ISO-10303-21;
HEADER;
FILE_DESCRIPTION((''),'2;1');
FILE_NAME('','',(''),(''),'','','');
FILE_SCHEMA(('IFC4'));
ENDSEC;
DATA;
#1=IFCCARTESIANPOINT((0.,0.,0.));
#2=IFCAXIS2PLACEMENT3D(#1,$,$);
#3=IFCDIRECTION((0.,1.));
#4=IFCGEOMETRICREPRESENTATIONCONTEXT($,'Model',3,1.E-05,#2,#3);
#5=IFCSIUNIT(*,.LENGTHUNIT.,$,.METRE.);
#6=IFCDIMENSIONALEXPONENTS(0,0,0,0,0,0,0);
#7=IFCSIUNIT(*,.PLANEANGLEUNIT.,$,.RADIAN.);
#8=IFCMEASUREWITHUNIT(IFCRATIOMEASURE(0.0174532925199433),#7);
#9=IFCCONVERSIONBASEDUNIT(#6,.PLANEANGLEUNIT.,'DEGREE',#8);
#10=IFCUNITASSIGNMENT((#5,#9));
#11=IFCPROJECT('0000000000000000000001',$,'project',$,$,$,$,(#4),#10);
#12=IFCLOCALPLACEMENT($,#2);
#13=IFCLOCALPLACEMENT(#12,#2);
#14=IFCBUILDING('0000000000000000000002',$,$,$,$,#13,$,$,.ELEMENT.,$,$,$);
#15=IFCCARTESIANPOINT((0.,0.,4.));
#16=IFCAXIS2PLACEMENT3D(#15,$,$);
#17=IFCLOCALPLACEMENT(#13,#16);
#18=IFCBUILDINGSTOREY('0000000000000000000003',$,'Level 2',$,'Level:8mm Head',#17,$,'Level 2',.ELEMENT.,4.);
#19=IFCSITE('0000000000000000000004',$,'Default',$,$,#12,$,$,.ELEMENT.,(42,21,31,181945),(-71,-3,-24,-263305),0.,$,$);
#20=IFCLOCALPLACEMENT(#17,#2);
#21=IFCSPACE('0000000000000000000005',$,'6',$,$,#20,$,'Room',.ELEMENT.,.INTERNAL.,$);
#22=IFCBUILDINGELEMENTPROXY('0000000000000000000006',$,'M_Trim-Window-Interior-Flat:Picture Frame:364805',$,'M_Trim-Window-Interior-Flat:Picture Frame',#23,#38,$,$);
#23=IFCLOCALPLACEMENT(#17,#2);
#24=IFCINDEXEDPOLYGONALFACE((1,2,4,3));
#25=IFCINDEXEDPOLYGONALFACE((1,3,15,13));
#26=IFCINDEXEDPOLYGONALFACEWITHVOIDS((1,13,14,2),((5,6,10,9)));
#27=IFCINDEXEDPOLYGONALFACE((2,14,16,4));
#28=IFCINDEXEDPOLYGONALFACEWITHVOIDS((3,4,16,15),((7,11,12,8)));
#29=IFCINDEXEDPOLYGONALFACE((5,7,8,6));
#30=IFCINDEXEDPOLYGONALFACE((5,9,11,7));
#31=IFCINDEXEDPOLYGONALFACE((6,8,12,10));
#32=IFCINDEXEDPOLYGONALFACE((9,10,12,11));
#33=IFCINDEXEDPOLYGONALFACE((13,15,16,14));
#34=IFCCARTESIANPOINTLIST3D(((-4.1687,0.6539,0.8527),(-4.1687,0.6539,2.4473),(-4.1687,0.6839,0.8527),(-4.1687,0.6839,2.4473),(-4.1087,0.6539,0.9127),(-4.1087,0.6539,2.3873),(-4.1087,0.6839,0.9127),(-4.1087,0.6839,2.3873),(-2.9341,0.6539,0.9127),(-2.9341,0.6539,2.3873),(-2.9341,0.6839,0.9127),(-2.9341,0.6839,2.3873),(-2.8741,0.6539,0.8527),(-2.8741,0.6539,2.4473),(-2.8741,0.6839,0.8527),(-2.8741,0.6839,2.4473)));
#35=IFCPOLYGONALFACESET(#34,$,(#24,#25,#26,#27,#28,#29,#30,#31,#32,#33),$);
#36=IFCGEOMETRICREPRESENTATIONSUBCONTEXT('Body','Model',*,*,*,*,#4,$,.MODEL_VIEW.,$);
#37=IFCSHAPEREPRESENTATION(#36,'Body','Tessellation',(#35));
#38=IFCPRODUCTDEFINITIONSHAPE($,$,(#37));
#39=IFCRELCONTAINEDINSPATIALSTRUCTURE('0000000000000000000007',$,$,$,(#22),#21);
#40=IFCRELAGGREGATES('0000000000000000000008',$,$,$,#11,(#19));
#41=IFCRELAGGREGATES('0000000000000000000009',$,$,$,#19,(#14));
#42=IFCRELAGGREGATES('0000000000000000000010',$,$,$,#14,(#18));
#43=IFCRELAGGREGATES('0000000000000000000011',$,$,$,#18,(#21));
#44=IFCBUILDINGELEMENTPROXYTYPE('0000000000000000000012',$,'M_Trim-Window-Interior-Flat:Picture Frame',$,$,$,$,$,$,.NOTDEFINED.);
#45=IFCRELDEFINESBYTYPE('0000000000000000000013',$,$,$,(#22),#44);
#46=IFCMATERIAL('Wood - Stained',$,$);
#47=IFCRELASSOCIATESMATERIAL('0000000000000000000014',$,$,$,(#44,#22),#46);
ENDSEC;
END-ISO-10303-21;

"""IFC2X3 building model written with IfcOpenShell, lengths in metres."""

from ifc_helpers import new_model, entity, si_unit, converted_unit, direction, frame, origin, place, context, subcontext, project, spatial, polyline, outline, extrude, source, transform, mapped, material, type_object, type_shapes, element, save


model = new_model("IFC2X3")

# Units and contexts
model_context = context("Model", 3, precision=1e-05, world=origin(), true_north=direction((0.0, 1.0)))
body_context = subcontext(model_context, "Body", "Model", "MODEL_VIEW")
ifc_project = project(units=[si_unit("LENGTHUNIT", "METRE"), converted_unit("PLANEANGLEUNIT", "DEGREE", entity("IfcRatioMeasure", 0.0174532925199433), si_unit("PLANEANGLEUNIT", "RADIAN"), dimensions=[0, 0, 0, 0, 0, 0, 0])], contexts=[model_context])

# Site, building, storey
site_placement = place(None, origin())
site = spatial("IfcSite", under=ifc_project, at=site_placement, Name="Default", CompositionType="ELEMENT", RefLatitude=(42, 21, 31, 181945), RefLongitude=(-71, -3, -24, -263305), RefElevation=0.0)
building_placement = place(site_placement, origin())
building = spatial("IfcBuilding", under=site, at=building_placement, CompositionType="ELEMENT")
storey_placement = place(building_placement, frame((0.0, 0.0, 4.0)))
storey = spatial("IfcBuildingStorey", under=building, at=storey_placement, Name="Level 2", ObjectType="Level:8mm Head", LongName="Level 2", CompositionType="ELEMENT", Elevation=4.0)

# Shared definitions
ifc_material_1 = material(Name="Wood - Stained")

# Shared definitions
building_element_proxy_type_1 = type_object("IfcBuildingElementProxyType", Name="M_Trim-Window-Interior-Flat:Picture Frame", PredefinedType="NOTDEFINED", material=ifc_material_1)
shared_shape_1 = source(origin(), body_context, "Body", "SweptSolid", [
    extrude(outline(polyline([(-0.6473, -0.7973), (0.6473, -0.7973), (0.6473, 0.7973), (-0.6473, 0.7973), (-0.6473, -0.7973)]), holes=[polyline([(-0.5873, -0.7373), (-0.5873, 0.7373), (0.5873, 0.7373), (0.5873, -0.7373), (-0.5873, -0.7373)])]), frame((0.0, -0.75, 0.0), z_axis=(0.0, 0.0, 1.0), x_axis=(-1.0, 0.0, 0.0)), (0.0, 0.0, 1.0), 0.03),
])
type_shapes(building_element_proxy_type_1, [shared_shape_1])

# Shared definitions
space_1_placement = place(storey_placement, origin())
space_1 = spatial("IfcSpace", under=storey, at=space_1_placement, Name="6", LongName="Room", CompositionType="ELEMENT", InteriorOrExteriorSpace="INTERNAL")

# Building element proxy
proxy_1_placement = place(space_1_placement, frame((-3.5214, 0.6539, 2.4), z_axis=(0.0, 1.0, 0.0), x_axis=(-1.0, 0.0, 0.0)))
element("IfcBuildingElementProxy", 1, at=proxy_1_placement, inside=space_1, type_object=building_element_proxy_type_1, material=ifc_material_1, Name="M_Trim-Window-Interior-Flat:Picture Frame:364805", ObjectType="M_Trim-Window-Interior-Flat:Picture Frame", context=body_context, shape_type="MappedRepresentation", body=[
    mapped(shared_shape_1, transform((0.0, 0.0, 0.0), scale=1.0)),
])

save(model, "model.ifc")
